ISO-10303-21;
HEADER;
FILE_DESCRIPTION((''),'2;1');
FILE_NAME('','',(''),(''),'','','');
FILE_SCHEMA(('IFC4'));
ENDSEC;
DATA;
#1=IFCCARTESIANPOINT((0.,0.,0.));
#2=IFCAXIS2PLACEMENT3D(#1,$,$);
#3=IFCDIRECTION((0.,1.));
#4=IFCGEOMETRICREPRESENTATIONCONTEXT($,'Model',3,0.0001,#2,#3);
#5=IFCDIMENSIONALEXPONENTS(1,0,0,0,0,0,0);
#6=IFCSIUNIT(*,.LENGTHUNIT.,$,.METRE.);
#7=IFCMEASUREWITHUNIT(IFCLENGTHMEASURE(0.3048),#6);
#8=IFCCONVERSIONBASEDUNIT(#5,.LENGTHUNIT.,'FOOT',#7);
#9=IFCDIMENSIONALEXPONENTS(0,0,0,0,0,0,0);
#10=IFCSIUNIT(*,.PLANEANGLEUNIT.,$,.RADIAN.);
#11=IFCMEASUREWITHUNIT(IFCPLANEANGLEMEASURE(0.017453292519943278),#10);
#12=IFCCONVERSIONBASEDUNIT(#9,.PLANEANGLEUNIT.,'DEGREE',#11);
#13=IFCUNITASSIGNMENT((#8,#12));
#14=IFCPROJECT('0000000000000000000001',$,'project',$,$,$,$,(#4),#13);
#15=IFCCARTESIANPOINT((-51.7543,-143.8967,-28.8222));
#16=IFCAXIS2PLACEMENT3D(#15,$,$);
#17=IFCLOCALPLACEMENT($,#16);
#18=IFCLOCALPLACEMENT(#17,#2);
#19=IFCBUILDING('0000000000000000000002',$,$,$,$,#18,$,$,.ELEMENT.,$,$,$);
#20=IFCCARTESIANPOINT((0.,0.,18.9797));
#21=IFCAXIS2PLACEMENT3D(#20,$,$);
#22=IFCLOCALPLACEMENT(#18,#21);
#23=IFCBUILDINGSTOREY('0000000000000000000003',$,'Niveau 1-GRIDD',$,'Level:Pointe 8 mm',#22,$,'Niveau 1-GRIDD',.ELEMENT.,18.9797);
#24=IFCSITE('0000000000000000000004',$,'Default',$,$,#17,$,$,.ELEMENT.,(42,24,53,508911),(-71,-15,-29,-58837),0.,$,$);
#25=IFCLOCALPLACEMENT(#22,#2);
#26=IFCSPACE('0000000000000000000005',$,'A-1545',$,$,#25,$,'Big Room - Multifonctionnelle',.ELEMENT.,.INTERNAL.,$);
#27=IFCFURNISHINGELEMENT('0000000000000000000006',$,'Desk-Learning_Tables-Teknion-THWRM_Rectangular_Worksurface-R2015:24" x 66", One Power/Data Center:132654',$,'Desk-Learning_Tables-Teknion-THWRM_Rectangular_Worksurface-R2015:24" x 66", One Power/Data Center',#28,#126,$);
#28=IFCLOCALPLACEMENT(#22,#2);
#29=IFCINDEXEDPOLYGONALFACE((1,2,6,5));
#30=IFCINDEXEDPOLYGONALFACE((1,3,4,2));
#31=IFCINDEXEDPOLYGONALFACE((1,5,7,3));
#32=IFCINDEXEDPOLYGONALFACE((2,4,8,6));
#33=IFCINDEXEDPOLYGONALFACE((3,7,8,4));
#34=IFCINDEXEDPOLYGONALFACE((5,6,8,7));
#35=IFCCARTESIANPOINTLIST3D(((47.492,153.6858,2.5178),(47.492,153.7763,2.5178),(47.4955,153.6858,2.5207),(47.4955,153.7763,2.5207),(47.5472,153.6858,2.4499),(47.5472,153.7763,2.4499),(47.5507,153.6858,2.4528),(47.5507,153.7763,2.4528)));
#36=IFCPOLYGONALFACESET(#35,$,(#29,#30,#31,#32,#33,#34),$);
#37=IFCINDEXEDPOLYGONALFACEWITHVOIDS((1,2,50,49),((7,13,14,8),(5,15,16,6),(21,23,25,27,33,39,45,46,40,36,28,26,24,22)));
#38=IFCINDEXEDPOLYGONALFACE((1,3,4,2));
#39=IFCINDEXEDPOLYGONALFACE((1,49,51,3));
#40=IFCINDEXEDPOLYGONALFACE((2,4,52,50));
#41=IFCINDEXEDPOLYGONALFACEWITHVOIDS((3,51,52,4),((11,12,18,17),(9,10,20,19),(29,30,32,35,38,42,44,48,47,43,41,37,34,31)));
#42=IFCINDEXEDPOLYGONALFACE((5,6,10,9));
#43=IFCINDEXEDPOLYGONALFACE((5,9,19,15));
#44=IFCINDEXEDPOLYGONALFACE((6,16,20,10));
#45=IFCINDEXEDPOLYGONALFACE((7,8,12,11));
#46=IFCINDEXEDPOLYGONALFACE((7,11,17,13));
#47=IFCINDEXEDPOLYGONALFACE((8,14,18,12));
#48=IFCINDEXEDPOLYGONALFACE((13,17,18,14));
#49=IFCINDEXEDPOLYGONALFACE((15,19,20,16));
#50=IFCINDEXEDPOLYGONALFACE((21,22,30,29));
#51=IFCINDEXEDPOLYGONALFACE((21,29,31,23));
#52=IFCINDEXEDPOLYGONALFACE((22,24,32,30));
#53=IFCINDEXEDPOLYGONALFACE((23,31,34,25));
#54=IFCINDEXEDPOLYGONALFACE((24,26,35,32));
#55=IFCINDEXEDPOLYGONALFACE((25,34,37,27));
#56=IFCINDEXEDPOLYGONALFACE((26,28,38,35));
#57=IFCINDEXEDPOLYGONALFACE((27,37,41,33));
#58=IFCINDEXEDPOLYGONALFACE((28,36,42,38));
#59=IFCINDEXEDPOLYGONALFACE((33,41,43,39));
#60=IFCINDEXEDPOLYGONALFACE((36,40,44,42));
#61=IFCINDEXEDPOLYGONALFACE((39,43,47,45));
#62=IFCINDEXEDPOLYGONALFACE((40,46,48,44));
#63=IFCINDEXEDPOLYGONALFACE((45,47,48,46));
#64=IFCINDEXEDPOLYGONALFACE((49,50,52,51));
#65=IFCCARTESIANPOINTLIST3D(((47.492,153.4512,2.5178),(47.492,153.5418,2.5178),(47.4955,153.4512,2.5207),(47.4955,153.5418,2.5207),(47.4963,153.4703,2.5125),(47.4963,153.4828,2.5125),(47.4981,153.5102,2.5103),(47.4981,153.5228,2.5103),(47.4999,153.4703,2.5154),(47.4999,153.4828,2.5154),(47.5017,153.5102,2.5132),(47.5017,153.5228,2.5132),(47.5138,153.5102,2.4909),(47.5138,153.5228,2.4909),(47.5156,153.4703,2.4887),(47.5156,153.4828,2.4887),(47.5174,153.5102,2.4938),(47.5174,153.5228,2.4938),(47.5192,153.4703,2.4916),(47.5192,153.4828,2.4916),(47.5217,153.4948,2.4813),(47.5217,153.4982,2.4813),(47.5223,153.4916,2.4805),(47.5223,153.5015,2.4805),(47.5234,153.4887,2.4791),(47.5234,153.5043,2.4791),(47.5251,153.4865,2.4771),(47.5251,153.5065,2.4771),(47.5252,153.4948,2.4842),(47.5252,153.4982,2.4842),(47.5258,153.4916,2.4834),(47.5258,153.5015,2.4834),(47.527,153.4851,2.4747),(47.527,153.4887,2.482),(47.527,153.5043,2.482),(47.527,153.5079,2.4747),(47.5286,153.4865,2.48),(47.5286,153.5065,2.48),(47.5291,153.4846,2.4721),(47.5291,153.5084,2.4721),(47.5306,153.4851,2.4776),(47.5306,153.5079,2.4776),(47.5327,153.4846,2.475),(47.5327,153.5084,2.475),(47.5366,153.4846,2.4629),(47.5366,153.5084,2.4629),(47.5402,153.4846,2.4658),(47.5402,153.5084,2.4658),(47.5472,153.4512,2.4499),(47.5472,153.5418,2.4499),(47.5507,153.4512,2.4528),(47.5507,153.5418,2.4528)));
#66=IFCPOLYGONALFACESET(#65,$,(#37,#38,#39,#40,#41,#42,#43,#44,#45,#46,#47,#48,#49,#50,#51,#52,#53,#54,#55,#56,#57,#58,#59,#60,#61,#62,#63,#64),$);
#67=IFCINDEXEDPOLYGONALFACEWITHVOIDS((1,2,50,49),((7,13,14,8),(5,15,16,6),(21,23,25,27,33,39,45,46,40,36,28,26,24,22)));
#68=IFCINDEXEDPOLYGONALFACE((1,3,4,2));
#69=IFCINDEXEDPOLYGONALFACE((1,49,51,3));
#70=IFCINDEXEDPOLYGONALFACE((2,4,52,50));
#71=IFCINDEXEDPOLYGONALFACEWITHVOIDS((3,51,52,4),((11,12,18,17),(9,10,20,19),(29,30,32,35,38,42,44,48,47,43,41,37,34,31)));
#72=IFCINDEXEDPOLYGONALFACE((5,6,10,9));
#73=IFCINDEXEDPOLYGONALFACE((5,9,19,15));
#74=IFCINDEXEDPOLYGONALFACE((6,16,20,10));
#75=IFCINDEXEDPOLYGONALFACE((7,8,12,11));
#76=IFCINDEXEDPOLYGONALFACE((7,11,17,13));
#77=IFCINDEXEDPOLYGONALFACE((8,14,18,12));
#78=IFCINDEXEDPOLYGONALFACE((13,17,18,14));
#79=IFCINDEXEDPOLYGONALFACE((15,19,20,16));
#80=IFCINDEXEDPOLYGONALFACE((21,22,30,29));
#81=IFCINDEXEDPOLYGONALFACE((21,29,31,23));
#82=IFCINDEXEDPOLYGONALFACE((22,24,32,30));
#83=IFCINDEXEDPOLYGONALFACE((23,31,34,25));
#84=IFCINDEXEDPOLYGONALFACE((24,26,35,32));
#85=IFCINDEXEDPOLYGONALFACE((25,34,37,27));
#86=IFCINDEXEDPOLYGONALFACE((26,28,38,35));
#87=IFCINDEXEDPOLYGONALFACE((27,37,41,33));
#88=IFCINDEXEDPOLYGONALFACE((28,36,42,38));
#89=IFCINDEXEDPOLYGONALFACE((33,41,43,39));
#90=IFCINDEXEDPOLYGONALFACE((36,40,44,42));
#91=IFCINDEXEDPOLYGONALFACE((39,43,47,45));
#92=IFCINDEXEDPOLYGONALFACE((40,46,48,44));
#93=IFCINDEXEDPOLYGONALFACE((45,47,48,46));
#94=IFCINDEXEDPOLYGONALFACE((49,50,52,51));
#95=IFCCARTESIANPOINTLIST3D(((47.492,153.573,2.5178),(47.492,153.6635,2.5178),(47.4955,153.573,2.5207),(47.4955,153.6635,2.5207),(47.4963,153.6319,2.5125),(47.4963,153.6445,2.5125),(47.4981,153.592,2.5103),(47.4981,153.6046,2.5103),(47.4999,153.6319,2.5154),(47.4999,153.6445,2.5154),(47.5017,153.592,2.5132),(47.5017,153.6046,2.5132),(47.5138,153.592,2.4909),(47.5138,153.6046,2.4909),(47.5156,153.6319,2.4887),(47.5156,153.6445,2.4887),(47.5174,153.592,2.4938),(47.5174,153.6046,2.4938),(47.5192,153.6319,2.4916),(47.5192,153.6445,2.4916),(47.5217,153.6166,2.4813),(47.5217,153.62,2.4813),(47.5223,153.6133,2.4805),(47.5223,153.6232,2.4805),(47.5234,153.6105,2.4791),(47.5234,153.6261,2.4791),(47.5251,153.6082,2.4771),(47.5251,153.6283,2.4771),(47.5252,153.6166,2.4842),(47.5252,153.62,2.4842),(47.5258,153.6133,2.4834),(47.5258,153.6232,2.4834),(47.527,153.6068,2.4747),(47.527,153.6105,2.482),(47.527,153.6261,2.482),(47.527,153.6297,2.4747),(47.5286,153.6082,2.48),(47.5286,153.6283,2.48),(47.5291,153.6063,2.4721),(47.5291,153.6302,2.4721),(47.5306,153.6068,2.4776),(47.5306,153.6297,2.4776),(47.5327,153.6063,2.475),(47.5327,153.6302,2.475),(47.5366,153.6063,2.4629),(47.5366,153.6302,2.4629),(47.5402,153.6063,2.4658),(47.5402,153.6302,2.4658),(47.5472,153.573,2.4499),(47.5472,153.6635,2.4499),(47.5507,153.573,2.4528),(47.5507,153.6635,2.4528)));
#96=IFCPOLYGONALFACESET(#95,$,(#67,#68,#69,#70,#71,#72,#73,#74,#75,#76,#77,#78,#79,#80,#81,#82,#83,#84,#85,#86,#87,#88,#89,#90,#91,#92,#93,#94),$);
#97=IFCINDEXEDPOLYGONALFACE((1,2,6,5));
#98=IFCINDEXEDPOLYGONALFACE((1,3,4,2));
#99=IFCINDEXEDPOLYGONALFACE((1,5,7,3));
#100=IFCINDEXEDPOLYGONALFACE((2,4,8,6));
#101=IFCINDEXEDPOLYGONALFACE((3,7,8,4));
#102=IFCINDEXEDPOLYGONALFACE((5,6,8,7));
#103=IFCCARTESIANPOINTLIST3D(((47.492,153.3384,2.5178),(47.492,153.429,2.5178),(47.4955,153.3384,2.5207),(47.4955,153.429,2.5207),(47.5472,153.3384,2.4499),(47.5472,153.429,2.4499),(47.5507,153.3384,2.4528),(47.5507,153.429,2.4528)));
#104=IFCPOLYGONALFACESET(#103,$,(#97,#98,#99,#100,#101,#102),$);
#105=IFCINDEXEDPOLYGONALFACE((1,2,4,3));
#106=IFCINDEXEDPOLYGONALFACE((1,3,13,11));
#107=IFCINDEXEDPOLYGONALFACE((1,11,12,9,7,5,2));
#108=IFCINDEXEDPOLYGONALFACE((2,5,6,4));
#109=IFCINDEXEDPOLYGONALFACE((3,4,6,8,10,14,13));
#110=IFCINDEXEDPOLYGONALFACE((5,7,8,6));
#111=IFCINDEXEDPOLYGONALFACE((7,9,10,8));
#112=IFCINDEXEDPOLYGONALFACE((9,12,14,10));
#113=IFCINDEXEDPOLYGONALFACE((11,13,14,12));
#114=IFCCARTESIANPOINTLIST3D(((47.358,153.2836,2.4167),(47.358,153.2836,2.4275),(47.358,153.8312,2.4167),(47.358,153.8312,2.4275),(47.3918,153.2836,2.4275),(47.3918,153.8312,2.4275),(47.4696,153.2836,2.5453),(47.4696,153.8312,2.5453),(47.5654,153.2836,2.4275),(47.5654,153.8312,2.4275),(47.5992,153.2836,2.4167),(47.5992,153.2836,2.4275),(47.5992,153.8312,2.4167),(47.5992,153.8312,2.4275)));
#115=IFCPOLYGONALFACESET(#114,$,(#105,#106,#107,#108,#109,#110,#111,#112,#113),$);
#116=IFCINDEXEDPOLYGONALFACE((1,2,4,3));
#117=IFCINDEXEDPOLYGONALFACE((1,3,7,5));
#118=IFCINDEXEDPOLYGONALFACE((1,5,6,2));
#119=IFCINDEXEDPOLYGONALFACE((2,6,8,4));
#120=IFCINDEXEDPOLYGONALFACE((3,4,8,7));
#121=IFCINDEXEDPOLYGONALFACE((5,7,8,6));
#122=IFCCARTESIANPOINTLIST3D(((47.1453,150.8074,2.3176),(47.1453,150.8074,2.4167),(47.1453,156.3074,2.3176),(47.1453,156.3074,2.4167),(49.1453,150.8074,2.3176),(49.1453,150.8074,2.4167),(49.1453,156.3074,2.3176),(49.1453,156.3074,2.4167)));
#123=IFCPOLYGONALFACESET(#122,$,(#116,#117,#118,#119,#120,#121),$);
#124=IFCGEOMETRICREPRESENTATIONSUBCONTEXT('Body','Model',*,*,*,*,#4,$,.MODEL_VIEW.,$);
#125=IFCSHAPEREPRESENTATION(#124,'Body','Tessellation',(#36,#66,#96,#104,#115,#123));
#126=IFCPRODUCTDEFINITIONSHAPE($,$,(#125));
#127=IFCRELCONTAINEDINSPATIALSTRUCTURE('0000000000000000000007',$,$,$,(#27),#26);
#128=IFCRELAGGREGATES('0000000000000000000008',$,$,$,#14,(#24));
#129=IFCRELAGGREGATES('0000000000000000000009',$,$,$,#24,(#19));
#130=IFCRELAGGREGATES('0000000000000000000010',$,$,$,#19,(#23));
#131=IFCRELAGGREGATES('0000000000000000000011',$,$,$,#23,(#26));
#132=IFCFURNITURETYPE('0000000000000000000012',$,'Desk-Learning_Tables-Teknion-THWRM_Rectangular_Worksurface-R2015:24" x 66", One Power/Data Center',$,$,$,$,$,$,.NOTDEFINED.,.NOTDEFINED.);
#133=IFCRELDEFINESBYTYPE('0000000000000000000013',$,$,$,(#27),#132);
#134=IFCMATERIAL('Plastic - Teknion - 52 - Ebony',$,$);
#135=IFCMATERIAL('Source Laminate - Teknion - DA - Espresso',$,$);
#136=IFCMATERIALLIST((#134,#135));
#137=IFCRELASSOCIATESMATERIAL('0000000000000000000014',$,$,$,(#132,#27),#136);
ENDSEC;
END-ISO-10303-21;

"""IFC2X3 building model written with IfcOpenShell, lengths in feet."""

from ifc_helpers import new_model, entity, si_unit, converted_unit, direction, frame, frame_2d, origin, place, context, subcontext, project, spatial, polyline, circle_curve, parameter, trimmed, segment, composite_curve, rectangle, outline, extrude, source, transform, mapped, material, material_list, type_object, type_shapes, element, save


model = new_model("IFC2X3")

# Units and contexts
model_context = context("Model", 3, precision=0.0001, world=origin(), true_north=direction((0.0, 1.0)))
body_context = subcontext(model_context, "Body", "Model", "MODEL_VIEW")
ifc_project = project(units=[converted_unit("LENGTHUNIT", "FOOT", entity("IfcLengthMeasure", 0.3048), si_unit("LENGTHUNIT", "METRE"), dimensions=[1, 0, 0, 0, 0, 0, 0]), converted_unit("PLANEANGLEUNIT", "DEGREE", entity("IfcPlaneAngleMeasure", 0.017453292519943278), si_unit("PLANEANGLEUNIT", "RADIAN"), dimensions=[0, 0, 0, 0, 0, 0, 0])], contexts=[model_context])

# Site, building, storey
site_placement = place(None, frame((-51.7543, -143.8967, -28.8222)))
site = spatial("IfcSite", under=ifc_project, at=site_placement, Name="Default", CompositionType="ELEMENT", RefLatitude=(42, 24, 53, 508911), RefLongitude=(-71, -15, -29, -58837), RefElevation=0.0)
building_placement = place(site_placement, origin())
building = spatial("IfcBuilding", under=site, at=building_placement, CompositionType="ELEMENT")
storey_placement = place(building_placement, frame((0.0, 0.0, 18.9797)))
storey = spatial("IfcBuildingStorey", under=building, at=storey_placement, Name="Niveau 1-GRIDD", ObjectType="Level:Pointe 8 mm", LongName="Niveau 1-GRIDD", CompositionType="ELEMENT", Elevation=18.9797)

# Shared definitions
space_1_placement = place(storey_placement, origin())
space_1 = spatial("IfcSpace", under=storey, at=space_1_placement, Name="A-1545", LongName="Big Room - Multifonctionnelle", CompositionType="ELEMENT", InteriorOrExteriorSpace="INTERNAL")

# Furnishing element
ifc_material_1 = material(Name="Plastic - Teknion - 52 - Ebony")
ifc_material_2 = material(Name="Source Laminate - Teknion - DA - Espresso")
ifc_material_list_1 = material_list([ifc_material_1, ifc_material_2])
furniture_type_1 = type_object("IfcFurnitureType", Name="Desk-Learning_Tables-Teknion-THWRM_Rectangular_Worksurface-R2015:24\" x 66\", One Power/Data Center", AssemblyPlace="NOTDEFINED", material=ifc_material_list_1)
shared_shape_1 = source(origin(), body_context, "Body", "SweptSolid", [
    extrude(rectangle(XDim=0.0875, YDim=0.0046, at=frame_2d((0.0, 0.0), x_axis=(0.0, 1.0))), frame((0.1284, 0.6239, 2.4853), z_axis=(1.0, 0.0, 0.0), x_axis=(0.0, 0.776046, -0.630676)), (0.0, 0.0, 1.0), 0.0906),
    extrude(outline(polyline([(-0.0453, -0.0438), (0.0453, -0.0438), (0.0453, 0.0438), (-0.0453, 0.0438), (-0.0453, -0.0438)]), holes=[polyline([(-0.0262, -0.0063), (-0.0137, -0.0063), (-0.0137, -0.0369), (-0.0262, -0.0369), (-0.0262, -0.0063)]), polyline([(0.0137, -0.0341), (0.0137, -0.0091), (0.0262, -0.0091), (0.0262, -0.0341), (0.0137, -0.0341)]), composite_curve([segment(polyline([(-0.0119, 0.027), (0.0119, 0.027)]), True, "CONTINUOUS"), segment(polyline([(0.0119, 0.027), (0.0119, 0.0151)]), True, "CONTINUOUS"), segment(trimmed(circle_curve(frame_2d((0.0, 0.0151), x_axis=(0.0, -1.0)), 0.0119), [parameter(270.0)], [parameter(90.0)], True, "PARAMETER"), False, "CONTINUOUS"), segment(polyline([(-0.0119, 0.0151), (-0.0119, 0.027)]), True, "CONTINUOUS")], self_intersect=False)]), frame((-0.0609, 0.6221, 2.4867), z_axis=(0.0, 0.776046, -0.630676), x_axis=(1.0, 0.0, 0.0)), (0.0, 0.0, 1.0), 0.0046),
    extrude(outline(polyline([(-0.0438, -0.0453), (0.0438, -0.0453), (0.0438, 0.0453), (-0.0438, 0.0453), (-0.0438, -0.0453)]), holes=[polyline([(-0.0063, -0.0262), (-0.0369, -0.0262), (-0.0369, -0.0137), (-0.0063, -0.0137), (-0.0063, -0.0262)]), polyline([(-0.0341, 0.0137), (-0.0341, 0.0262), (-0.0091, 0.0262), (-0.0091, 0.0137), (-0.0341, 0.0137)]), composite_curve([segment(polyline([(0.027, -0.0119), (0.0151, -0.0119)]), True, "CONTINUOUS"), segment(trimmed(circle_curve(frame_2d((0.0151, 0.0), x_axis=(-1.0, 0.0)), 0.0119), [parameter(270.0)], [parameter(90.0)], True, "PARAMETER"), False, "CONTINUOUS"), segment(polyline([(0.0151, 0.0119), (0.027, 0.0119)]), True, "CONTINUOUS"), segment(polyline([(0.027, 0.0119), (0.027, -0.0119)]), True, "CONTINUOUS")], self_intersect=False)]), frame((0.0609, 0.6221, 2.4867), z_axis=(0.0, 0.776046, -0.630676), x_axis=(0.0, -0.630676, -0.776046)), (0.0, 0.0, 1.0), 0.0046),
    extrude(rectangle(XDim=0.0875, YDim=0.0046, at=frame_2d((0.0, 0.0), x_axis=(0.0, 1.0))), frame((-0.219, 0.6239, 2.4853), z_axis=(1.0, 0.0, 0.0), x_axis=(0.0, 0.776046, -0.630676)), (0.0, 0.0, 1.0), 0.0906),
    extrude(outline(polyline([(-0.0586, -0.0638), (0.0826, -0.0638), (0.0371, 0.0811), (0.0557, 0.1093), (0.0467, 0.1152), (-0.0862, -0.086), (-0.0772, -0.092), (-0.0586, -0.0638)])), frame((-0.2738, 0.6679, 2.4412), z_axis=(1.0, 0.0, 0.0), x_axis=(0.0, -0.551103, 0.834437)), (0.0, 0.0, 1.0), 0.5475),
    extrude(rectangle(XDim=5.5, YDim=2.0, at=frame_2d((0.0, 0.0), x_axis=(1.0, 0.0))), frame((0.0, 0.0, 2.3176), z_axis=(0.0, 0.0, 1.0), x_axis=(-1.0, 0.0, 0.0)), (0.0, 0.0, 1.0), 0.0991),
])
type_shapes(furniture_type_1, [shared_shape_1])
for number, where, z_axis, x_axis, name in (
    (1, (48.1453, 153.5574, 0.0), (0.0, 0.0, 1.0), (0.0, 1.0, 0.0), "Desk-Learning_Tables-Teknion-THWRM_Rectangular_Worksurface-R2015:24\" x 66\", One Power/Data Center:132654"),
):
    element("IfcFurnishingElement", number, at=place(space_1_placement, frame(where, z_axis=z_axis, x_axis=x_axis)), inside=space_1, type_object=furniture_type_1, material=ifc_material_list_1, Name=name, ObjectType="Desk-Learning_Tables-Teknion-THWRM_Rectangular_Worksurface-R2015:24\" x 66\", One Power/Data Center", context=body_context, shape_type="MappedRepresentation", body=[
        mapped(shared_shape_1, transform((0.0, 0.0, 0.0), scale=1.0)),
    ])

save(model, "model.ifc")
